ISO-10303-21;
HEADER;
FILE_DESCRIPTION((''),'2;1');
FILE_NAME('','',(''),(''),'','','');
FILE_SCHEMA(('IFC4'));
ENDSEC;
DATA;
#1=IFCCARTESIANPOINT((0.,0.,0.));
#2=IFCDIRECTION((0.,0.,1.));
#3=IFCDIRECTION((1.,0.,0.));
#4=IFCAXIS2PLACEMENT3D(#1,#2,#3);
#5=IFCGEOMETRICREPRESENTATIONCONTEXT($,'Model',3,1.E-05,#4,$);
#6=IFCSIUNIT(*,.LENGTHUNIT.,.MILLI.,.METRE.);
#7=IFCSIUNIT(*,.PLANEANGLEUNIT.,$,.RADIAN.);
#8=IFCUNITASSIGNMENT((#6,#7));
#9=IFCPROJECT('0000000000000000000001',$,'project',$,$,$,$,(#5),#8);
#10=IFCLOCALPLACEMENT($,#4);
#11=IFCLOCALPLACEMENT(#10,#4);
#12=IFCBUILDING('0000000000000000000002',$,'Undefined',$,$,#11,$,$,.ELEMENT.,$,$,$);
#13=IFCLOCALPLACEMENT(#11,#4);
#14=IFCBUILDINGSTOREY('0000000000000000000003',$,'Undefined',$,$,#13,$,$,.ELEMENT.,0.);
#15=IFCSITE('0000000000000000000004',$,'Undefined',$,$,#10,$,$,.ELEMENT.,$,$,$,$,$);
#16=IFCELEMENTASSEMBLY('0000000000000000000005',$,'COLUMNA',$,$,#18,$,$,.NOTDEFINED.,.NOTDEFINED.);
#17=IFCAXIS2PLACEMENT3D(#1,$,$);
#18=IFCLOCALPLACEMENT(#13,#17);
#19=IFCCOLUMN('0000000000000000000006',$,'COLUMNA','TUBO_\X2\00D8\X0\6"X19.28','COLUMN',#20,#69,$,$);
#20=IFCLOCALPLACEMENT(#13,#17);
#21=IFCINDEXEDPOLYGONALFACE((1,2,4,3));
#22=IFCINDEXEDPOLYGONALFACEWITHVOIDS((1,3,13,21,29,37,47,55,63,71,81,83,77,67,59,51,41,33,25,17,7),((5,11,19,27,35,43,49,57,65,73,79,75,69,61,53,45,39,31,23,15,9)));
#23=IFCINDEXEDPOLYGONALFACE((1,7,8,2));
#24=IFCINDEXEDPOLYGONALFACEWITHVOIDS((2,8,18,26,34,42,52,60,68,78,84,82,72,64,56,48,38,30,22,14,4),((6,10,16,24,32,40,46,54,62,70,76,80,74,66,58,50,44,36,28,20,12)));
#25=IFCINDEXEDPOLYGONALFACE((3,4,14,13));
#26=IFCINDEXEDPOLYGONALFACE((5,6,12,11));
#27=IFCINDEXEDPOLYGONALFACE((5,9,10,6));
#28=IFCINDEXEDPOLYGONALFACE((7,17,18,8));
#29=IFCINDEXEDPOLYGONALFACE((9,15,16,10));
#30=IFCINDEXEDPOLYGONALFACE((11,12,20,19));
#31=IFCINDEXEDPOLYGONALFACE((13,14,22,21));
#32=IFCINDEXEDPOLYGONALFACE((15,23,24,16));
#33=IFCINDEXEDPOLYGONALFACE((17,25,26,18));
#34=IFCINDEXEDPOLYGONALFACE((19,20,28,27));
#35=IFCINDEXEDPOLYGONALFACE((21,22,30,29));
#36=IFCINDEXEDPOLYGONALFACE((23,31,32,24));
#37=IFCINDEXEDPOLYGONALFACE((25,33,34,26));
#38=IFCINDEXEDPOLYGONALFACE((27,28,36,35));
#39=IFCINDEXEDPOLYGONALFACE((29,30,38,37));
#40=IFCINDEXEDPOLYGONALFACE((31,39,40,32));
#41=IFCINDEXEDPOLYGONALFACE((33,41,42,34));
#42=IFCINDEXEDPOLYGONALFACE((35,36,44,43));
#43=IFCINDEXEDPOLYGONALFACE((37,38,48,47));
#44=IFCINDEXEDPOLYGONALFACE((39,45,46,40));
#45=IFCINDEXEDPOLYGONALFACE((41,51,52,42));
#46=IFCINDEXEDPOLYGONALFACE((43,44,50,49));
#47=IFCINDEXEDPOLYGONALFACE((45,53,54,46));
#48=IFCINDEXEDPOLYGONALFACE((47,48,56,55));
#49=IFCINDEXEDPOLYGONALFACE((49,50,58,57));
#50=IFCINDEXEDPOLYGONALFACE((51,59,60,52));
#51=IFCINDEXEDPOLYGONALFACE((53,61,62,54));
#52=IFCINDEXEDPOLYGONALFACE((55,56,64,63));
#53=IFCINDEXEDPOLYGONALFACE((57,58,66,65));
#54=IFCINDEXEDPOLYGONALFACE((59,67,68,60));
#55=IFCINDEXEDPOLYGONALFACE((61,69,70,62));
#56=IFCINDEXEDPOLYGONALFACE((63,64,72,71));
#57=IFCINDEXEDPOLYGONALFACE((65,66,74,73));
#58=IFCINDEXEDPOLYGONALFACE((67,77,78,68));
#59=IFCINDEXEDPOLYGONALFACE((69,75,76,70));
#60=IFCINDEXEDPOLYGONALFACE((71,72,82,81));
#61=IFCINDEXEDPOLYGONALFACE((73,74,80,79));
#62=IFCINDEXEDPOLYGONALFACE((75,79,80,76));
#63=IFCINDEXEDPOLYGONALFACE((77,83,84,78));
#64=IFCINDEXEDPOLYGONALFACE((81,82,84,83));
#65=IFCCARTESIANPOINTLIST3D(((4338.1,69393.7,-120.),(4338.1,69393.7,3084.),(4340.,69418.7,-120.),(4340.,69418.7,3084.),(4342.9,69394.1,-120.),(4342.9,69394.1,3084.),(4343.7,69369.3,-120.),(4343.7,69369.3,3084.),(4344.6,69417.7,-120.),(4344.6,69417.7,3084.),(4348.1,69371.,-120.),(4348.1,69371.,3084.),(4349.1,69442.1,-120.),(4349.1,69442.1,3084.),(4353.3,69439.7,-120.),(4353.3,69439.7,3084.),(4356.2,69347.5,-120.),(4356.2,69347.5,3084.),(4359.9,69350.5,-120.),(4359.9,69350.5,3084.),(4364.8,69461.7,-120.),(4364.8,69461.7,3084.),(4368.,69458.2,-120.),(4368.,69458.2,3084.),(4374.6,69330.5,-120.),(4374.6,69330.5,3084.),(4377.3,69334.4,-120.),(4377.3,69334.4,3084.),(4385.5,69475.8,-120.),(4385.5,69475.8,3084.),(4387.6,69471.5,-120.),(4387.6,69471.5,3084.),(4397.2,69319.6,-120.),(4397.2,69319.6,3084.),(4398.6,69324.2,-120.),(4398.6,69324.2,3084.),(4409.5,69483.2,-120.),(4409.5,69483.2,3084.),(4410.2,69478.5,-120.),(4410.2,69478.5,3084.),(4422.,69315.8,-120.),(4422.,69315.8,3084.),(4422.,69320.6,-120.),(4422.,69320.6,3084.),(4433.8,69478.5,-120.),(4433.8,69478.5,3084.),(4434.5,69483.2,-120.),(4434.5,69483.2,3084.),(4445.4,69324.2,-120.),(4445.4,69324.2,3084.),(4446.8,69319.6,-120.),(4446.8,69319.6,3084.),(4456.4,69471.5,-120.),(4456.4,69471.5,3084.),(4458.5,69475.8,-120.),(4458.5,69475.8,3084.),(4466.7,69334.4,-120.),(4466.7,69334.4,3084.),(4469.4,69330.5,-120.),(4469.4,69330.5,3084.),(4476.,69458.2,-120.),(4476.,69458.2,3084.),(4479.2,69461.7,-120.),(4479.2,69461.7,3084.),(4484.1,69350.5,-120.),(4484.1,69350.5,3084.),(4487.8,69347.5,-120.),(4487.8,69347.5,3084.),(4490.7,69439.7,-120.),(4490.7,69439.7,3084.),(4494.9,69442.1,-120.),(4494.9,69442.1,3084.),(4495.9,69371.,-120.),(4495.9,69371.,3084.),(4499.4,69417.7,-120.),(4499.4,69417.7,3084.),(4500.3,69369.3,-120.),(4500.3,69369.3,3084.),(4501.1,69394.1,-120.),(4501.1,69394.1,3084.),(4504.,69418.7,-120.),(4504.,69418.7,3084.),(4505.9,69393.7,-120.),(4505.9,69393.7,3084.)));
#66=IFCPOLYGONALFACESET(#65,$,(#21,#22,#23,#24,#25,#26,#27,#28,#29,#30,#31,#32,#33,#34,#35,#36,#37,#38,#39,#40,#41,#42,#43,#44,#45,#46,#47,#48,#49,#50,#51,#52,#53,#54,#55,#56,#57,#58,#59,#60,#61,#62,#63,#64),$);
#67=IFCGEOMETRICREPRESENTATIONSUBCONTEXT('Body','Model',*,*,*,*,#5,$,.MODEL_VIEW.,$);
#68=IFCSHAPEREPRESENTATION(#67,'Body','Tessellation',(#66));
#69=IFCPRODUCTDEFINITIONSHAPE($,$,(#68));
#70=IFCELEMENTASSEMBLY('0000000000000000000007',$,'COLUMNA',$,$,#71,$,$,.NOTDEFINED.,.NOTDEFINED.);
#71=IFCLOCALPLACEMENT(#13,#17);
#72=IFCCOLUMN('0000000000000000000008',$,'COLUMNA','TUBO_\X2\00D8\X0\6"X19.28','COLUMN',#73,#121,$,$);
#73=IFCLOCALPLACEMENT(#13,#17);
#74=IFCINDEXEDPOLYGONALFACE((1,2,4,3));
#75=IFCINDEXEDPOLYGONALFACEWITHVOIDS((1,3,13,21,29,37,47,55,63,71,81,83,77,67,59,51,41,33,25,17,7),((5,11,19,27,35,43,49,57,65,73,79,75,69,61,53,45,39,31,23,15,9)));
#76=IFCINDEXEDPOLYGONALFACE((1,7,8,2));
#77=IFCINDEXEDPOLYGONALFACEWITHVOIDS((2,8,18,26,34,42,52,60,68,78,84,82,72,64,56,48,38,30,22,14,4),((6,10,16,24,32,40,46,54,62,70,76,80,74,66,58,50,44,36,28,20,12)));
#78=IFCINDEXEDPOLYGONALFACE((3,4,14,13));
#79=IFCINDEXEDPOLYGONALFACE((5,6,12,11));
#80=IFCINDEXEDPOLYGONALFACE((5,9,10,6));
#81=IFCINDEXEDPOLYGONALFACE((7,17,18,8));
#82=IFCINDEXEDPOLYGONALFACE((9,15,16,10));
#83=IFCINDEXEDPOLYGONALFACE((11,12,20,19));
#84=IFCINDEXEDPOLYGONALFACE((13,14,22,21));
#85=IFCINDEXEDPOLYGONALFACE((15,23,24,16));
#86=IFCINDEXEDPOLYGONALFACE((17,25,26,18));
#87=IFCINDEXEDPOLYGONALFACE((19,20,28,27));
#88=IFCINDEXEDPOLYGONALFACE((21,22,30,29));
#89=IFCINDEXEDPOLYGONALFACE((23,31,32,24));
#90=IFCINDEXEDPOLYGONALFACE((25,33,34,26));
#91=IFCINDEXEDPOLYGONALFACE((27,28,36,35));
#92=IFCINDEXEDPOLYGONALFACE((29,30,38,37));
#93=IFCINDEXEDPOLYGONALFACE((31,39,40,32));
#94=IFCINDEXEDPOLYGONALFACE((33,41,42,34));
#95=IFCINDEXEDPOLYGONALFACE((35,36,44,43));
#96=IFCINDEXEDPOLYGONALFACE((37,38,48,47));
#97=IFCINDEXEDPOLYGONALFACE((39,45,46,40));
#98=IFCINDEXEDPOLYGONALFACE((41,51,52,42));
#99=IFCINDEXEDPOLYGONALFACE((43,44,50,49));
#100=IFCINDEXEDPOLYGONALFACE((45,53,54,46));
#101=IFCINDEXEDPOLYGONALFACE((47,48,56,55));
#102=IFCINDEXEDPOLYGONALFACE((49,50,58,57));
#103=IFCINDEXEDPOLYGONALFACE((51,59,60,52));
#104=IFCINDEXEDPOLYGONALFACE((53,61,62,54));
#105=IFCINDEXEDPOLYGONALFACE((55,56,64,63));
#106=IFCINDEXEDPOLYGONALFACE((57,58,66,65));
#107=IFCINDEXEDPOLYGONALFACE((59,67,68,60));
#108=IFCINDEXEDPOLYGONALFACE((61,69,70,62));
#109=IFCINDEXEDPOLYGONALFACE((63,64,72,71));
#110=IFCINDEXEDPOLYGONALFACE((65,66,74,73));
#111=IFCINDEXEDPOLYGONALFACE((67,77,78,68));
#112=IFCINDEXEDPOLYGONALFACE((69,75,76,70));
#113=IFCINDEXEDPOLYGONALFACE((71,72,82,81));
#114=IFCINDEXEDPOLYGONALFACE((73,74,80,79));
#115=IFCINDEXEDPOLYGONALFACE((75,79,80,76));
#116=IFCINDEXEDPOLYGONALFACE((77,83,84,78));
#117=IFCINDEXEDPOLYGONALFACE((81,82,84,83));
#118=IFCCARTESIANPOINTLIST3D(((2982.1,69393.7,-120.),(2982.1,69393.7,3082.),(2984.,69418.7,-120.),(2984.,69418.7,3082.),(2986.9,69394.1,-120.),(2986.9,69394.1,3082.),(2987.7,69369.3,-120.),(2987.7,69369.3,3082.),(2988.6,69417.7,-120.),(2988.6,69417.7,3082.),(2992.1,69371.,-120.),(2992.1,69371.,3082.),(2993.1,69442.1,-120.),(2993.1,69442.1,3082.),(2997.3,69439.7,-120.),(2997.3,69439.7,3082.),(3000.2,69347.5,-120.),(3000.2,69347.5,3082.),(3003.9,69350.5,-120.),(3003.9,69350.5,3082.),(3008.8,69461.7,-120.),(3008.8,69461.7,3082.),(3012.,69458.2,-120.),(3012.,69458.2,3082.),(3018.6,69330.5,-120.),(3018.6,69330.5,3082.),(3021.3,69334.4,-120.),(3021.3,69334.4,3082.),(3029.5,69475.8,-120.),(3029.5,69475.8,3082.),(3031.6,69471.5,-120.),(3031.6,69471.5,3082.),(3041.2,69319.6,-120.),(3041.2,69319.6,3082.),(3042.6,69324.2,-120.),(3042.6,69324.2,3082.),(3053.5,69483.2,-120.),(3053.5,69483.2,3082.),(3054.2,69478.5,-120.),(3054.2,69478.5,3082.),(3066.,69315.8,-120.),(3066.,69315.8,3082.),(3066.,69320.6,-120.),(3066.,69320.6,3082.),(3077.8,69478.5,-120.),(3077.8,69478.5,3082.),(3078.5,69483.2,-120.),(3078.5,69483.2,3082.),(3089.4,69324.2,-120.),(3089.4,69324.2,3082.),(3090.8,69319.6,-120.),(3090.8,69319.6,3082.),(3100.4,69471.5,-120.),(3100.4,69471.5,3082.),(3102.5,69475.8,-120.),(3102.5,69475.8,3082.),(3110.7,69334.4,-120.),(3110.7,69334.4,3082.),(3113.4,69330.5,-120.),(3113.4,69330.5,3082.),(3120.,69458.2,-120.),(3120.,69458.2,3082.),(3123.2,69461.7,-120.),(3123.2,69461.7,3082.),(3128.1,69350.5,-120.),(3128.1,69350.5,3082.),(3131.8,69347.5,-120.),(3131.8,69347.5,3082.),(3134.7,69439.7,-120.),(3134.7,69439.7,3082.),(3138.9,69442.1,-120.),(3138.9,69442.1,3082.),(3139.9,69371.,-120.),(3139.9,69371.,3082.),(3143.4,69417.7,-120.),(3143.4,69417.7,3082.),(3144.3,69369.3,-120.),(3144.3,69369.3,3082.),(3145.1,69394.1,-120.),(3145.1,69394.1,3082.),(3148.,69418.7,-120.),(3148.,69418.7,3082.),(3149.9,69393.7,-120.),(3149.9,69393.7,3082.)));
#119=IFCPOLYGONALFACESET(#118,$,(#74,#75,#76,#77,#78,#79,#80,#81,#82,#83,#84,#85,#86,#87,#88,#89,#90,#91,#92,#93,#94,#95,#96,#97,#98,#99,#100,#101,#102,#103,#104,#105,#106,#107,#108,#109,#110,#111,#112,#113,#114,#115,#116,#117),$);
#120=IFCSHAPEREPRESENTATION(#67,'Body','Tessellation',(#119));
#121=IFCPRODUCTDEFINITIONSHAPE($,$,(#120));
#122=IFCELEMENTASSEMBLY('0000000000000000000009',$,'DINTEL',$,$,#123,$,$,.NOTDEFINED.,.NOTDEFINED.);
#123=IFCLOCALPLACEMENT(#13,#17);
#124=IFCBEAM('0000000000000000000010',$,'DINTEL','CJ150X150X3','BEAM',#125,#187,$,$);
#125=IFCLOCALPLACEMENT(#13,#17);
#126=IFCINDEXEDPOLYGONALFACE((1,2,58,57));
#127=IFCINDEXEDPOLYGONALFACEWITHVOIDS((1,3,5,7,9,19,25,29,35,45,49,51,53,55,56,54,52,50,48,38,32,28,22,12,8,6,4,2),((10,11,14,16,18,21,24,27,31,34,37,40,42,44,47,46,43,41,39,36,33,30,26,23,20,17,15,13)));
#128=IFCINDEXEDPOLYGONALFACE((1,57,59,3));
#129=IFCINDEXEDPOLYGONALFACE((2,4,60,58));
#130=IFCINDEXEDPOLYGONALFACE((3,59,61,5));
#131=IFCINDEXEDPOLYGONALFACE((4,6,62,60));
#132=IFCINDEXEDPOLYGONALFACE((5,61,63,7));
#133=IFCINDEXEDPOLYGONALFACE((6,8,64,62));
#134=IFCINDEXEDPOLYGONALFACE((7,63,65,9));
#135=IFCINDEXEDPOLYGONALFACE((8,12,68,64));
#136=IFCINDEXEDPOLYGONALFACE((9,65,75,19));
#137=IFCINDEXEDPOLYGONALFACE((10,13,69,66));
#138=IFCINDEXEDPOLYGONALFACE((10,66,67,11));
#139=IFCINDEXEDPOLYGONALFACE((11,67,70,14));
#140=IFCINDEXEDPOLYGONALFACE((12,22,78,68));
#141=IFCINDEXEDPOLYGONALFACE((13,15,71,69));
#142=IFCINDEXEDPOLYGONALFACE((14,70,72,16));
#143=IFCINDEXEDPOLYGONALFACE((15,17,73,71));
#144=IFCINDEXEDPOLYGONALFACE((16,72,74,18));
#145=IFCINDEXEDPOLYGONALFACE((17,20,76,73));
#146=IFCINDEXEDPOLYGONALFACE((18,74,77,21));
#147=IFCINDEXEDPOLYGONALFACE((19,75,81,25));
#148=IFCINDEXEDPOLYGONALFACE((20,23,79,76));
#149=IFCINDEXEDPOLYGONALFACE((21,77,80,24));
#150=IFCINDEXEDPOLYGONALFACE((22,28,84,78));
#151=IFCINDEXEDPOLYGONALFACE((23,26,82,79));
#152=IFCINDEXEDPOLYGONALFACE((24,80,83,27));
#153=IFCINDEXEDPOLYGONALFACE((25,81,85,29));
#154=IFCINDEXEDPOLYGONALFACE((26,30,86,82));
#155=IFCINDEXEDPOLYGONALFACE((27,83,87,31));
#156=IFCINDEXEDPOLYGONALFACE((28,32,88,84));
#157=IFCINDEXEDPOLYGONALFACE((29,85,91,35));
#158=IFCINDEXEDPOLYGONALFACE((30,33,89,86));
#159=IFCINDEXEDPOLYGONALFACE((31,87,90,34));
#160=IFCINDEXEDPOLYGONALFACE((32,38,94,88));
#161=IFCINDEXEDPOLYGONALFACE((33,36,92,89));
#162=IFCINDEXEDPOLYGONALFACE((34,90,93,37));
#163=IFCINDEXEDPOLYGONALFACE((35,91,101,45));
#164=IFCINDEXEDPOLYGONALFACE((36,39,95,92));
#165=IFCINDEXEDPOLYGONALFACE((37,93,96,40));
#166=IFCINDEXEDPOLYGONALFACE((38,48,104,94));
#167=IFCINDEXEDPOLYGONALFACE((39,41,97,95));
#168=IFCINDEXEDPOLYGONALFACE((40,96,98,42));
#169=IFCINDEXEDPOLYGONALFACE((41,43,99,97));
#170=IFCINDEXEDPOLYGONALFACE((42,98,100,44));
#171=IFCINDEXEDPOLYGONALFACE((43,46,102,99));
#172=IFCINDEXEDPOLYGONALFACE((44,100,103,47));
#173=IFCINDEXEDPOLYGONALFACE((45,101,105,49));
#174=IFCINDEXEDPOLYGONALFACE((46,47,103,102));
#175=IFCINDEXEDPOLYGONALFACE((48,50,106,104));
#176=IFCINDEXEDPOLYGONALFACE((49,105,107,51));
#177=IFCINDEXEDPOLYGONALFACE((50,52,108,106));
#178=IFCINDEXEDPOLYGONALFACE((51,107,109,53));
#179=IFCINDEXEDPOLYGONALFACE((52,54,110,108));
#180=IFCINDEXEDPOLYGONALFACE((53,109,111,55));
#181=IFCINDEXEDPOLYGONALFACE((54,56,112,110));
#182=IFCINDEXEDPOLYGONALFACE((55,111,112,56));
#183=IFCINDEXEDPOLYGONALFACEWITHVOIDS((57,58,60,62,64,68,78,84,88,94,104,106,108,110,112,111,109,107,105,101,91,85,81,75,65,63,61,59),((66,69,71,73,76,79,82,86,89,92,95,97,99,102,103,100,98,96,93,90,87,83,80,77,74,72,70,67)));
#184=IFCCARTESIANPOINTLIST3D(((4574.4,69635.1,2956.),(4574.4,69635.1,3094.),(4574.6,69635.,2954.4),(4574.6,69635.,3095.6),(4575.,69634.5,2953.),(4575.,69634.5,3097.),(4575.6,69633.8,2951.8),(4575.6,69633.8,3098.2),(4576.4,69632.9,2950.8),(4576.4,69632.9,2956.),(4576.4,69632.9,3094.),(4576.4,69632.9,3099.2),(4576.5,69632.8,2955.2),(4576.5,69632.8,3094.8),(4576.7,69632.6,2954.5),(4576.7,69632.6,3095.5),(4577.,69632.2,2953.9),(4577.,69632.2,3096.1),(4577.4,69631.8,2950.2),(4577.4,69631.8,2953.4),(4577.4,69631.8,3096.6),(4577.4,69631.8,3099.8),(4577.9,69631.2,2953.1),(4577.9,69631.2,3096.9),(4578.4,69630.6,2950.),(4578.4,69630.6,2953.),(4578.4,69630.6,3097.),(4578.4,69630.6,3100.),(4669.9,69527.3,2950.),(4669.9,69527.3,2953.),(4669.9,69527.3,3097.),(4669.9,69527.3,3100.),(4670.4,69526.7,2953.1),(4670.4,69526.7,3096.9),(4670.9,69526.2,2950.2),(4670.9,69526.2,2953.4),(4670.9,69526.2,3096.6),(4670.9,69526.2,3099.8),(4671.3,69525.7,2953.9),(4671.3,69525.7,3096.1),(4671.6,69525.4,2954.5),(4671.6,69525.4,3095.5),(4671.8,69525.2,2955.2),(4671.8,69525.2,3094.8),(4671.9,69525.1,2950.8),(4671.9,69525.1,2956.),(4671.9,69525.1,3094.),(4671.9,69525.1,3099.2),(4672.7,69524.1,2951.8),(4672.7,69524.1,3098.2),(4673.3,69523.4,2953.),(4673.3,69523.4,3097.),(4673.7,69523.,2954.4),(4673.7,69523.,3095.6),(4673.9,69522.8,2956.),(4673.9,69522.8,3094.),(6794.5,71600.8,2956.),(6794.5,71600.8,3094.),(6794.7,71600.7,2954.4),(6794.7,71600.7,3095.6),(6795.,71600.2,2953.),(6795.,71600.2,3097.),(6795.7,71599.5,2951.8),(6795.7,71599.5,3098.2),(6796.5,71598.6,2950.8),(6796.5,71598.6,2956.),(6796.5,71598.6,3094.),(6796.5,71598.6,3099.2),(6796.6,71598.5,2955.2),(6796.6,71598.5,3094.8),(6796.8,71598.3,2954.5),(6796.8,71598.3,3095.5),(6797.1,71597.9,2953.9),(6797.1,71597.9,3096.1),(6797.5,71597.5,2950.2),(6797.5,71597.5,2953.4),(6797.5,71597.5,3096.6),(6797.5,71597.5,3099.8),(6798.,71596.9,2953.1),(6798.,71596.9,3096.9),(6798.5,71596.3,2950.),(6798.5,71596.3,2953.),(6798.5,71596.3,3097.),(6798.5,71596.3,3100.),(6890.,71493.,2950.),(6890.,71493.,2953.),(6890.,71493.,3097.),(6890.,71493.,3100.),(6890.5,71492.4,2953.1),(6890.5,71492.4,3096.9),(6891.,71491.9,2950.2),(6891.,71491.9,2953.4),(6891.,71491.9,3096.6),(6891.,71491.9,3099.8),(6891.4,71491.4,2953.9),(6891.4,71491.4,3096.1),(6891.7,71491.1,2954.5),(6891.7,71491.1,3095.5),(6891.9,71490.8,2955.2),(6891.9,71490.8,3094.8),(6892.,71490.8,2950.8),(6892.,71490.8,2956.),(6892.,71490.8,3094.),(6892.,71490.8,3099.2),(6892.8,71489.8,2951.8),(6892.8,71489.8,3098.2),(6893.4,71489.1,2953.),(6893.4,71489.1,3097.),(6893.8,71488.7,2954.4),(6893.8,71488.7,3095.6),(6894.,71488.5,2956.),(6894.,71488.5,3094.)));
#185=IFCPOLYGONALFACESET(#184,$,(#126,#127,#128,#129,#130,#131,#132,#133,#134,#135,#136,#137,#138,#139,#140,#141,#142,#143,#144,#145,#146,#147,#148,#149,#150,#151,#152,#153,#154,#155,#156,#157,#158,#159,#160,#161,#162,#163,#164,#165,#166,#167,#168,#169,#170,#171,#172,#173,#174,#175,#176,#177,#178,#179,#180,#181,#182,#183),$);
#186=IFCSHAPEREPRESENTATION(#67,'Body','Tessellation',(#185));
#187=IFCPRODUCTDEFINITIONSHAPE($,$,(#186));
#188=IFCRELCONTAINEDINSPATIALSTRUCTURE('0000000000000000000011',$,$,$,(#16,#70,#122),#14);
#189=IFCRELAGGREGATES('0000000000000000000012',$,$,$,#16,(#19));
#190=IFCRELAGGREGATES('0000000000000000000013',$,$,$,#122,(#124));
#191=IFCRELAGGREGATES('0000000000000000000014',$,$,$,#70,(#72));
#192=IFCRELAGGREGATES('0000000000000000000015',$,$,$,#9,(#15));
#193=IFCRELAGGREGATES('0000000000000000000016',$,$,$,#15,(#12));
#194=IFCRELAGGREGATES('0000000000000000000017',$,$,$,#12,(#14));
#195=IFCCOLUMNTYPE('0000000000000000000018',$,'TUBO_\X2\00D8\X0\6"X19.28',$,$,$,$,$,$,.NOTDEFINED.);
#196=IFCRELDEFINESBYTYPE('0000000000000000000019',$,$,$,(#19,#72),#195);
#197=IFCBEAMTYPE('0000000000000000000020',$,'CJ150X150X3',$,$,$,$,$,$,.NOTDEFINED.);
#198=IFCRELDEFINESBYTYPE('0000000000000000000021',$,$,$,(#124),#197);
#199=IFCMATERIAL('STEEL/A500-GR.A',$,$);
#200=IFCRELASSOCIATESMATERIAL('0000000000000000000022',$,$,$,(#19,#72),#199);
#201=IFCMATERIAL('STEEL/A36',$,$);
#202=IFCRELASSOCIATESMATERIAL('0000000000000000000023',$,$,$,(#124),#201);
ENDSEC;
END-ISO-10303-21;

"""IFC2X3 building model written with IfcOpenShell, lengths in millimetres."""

from ifc_helpers import new_model, si_unit, frame, origin_with_axes, origin_2d_with_axis, place, context, subcontext, project, spatial, hollow_rectangle, hollow_circle, extrude, clip, halfspace, material, type_object, element, aggregate, save


model = new_model("IFC2X3")

# Units and contexts
model_context = context("Model", 3, precision=1e-05, world=origin_with_axes())
body_context = subcontext(model_context, "Body", "Model", "MODEL_VIEW")
ifc_project = project(units=[si_unit("LENGTHUNIT", "METRE", prefix="MILLI"), si_unit("PLANEANGLEUNIT", "RADIAN")], contexts=[model_context])

# Site, building, storey
site_placement = place(None, origin_with_axes())
site = spatial("IfcSite", under=ifc_project, at=site_placement, Name="Undefined", CompositionType="ELEMENT")
building_placement = place(site_placement, origin_with_axes())
building = spatial("IfcBuilding", under=site, at=building_placement, Name="Undefined", CompositionType="ELEMENT")
storey_placement = place(building_placement, origin_with_axes())
storey = spatial("IfcBuildingStorey", under=building, at=storey_placement, Name="Undefined", CompositionType="ELEMENT", Elevation=0.0)

# Element assemblies, columns
assembly_1_placement = place(storey_placement, origin_with_axes())
assembly_1 = element("IfcElementAssembly", 1, at=assembly_1_placement, inside=storey, Name="COLUMNA", AssemblyPlace="NOTDEFINED", PredefinedType="NOTDEFINED")
ifc_material_1 = material(Name="STEEL/A500-GR.A")
column_type = type_object("IfcColumnType", Name="TUBO_Ø6\"X19.28", PredefinedType="NOTDEFINED")
column_1_placement = place(assembly_1_placement, frame((4422.0, 69400.0, -120.0), z_axis=(0.0, 0.0, 1.0), x_axis=(-1.0, 0.0, 0.0)))
column_1 = element("IfcColumn", 2, at=column_1_placement, type_object=column_type, material=ifc_material_1, Name="COLUMNA", Description="TUBO_Ø6\"X19.28", ObjectType="COLUMN", context=body_context, shape_type="Clipping", body=[
    clip(extrude(hollow_circle(Radius=84.2, WallThickness=4.8, at=origin_2d_with_axis()), frame((0.0, 0.0, 3220.0), z_axis=(0.0, 0.0, -1.0), x_axis=(0.0, 1.0, 0.0)), (0.0, 0.0, 1.0), 3220.0), halfspace(frame((0.0, 84.1, 3204.0), z_axis=(0.0, 0.0, -1.0), x_axis=(-1.0, 0.0, 0.0)), True)),
])
aggregate(assembly_1, [column_1])
assembly_2_placement = place(storey_placement, origin_with_axes())
assembly_2 = element("IfcElementAssembly", 3, at=assembly_2_placement, inside=storey, Name="COLUMNA", AssemblyPlace="NOTDEFINED", PredefinedType="NOTDEFINED")
column_2_placement = place(assembly_2_placement, frame((3066.0, 69400.0, -120.0), z_axis=(0.0, 0.0, 1.0), x_axis=(-1.0, 0.0, 0.0)))
column_2 = element("IfcColumn", 4, at=column_2_placement, type_object=column_type, material=ifc_material_1, Name="COLUMNA", Description="TUBO_Ø6\"X19.28", ObjectType="COLUMN", context=body_context, shape_type="SweptSolid", body=[
    extrude(hollow_circle(Radius=84.2, WallThickness=4.8, at=origin_2d_with_axis()), frame((0.0, 0.0, 3202.0), z_axis=(0.0, 0.0, -1.0), x_axis=(0.0, 1.0, 0.0)), (0.0, 0.0, 1.0), 3202.0),
])

# Element assembly, beam
assembly_3_placement = place(storey_placement, origin_with_axes())
assembly_3 = element("IfcElementAssembly", 5, at=assembly_3_placement, inside=storey, Name="DINTEL", AssemblyPlace="NOTDEFINED", PredefinedType="NOTDEFINED")
ifc_material_2 = material(Name="STEEL/A36")
beam_type_1 = type_object("IfcBeamType", Name="CJ150X150X3", PredefinedType="NOTDEFINED")
beam_1_placement = place(assembly_3_placement, frame((4624.1, 69579.0, 3025.0), z_axis=(0.0, 0.0, 1.0), x_axis=(0.7487, 0.662909, 0.0)))
beam_1 = element("IfcBeam", 6, at=beam_1_placement, type_object=beam_type_1, material=ifc_material_2, Name="DINTEL", Description="CJ150X150X3", ObjectType="BEAM", context=body_context, shape_type="SweptSolid", body=[
    extrude(hollow_rectangle(XDim=150.0, YDim=150.0, WallThickness=3.0, InnerFilletRadius=3.0, OuterFilletRadius=6.0, at=origin_2d_with_axis()), frame((2965.3, 0.0, 0.0), z_axis=(-1.0, 0.0, 0.0), x_axis=(0.0, -1.0, 0.0)), (0.0, 0.0, 1.0), 2965.2),
])

aggregate(assembly_3, [beam_1])

aggregate(assembly_2, [column_2])

save(model, "model.ifc")
